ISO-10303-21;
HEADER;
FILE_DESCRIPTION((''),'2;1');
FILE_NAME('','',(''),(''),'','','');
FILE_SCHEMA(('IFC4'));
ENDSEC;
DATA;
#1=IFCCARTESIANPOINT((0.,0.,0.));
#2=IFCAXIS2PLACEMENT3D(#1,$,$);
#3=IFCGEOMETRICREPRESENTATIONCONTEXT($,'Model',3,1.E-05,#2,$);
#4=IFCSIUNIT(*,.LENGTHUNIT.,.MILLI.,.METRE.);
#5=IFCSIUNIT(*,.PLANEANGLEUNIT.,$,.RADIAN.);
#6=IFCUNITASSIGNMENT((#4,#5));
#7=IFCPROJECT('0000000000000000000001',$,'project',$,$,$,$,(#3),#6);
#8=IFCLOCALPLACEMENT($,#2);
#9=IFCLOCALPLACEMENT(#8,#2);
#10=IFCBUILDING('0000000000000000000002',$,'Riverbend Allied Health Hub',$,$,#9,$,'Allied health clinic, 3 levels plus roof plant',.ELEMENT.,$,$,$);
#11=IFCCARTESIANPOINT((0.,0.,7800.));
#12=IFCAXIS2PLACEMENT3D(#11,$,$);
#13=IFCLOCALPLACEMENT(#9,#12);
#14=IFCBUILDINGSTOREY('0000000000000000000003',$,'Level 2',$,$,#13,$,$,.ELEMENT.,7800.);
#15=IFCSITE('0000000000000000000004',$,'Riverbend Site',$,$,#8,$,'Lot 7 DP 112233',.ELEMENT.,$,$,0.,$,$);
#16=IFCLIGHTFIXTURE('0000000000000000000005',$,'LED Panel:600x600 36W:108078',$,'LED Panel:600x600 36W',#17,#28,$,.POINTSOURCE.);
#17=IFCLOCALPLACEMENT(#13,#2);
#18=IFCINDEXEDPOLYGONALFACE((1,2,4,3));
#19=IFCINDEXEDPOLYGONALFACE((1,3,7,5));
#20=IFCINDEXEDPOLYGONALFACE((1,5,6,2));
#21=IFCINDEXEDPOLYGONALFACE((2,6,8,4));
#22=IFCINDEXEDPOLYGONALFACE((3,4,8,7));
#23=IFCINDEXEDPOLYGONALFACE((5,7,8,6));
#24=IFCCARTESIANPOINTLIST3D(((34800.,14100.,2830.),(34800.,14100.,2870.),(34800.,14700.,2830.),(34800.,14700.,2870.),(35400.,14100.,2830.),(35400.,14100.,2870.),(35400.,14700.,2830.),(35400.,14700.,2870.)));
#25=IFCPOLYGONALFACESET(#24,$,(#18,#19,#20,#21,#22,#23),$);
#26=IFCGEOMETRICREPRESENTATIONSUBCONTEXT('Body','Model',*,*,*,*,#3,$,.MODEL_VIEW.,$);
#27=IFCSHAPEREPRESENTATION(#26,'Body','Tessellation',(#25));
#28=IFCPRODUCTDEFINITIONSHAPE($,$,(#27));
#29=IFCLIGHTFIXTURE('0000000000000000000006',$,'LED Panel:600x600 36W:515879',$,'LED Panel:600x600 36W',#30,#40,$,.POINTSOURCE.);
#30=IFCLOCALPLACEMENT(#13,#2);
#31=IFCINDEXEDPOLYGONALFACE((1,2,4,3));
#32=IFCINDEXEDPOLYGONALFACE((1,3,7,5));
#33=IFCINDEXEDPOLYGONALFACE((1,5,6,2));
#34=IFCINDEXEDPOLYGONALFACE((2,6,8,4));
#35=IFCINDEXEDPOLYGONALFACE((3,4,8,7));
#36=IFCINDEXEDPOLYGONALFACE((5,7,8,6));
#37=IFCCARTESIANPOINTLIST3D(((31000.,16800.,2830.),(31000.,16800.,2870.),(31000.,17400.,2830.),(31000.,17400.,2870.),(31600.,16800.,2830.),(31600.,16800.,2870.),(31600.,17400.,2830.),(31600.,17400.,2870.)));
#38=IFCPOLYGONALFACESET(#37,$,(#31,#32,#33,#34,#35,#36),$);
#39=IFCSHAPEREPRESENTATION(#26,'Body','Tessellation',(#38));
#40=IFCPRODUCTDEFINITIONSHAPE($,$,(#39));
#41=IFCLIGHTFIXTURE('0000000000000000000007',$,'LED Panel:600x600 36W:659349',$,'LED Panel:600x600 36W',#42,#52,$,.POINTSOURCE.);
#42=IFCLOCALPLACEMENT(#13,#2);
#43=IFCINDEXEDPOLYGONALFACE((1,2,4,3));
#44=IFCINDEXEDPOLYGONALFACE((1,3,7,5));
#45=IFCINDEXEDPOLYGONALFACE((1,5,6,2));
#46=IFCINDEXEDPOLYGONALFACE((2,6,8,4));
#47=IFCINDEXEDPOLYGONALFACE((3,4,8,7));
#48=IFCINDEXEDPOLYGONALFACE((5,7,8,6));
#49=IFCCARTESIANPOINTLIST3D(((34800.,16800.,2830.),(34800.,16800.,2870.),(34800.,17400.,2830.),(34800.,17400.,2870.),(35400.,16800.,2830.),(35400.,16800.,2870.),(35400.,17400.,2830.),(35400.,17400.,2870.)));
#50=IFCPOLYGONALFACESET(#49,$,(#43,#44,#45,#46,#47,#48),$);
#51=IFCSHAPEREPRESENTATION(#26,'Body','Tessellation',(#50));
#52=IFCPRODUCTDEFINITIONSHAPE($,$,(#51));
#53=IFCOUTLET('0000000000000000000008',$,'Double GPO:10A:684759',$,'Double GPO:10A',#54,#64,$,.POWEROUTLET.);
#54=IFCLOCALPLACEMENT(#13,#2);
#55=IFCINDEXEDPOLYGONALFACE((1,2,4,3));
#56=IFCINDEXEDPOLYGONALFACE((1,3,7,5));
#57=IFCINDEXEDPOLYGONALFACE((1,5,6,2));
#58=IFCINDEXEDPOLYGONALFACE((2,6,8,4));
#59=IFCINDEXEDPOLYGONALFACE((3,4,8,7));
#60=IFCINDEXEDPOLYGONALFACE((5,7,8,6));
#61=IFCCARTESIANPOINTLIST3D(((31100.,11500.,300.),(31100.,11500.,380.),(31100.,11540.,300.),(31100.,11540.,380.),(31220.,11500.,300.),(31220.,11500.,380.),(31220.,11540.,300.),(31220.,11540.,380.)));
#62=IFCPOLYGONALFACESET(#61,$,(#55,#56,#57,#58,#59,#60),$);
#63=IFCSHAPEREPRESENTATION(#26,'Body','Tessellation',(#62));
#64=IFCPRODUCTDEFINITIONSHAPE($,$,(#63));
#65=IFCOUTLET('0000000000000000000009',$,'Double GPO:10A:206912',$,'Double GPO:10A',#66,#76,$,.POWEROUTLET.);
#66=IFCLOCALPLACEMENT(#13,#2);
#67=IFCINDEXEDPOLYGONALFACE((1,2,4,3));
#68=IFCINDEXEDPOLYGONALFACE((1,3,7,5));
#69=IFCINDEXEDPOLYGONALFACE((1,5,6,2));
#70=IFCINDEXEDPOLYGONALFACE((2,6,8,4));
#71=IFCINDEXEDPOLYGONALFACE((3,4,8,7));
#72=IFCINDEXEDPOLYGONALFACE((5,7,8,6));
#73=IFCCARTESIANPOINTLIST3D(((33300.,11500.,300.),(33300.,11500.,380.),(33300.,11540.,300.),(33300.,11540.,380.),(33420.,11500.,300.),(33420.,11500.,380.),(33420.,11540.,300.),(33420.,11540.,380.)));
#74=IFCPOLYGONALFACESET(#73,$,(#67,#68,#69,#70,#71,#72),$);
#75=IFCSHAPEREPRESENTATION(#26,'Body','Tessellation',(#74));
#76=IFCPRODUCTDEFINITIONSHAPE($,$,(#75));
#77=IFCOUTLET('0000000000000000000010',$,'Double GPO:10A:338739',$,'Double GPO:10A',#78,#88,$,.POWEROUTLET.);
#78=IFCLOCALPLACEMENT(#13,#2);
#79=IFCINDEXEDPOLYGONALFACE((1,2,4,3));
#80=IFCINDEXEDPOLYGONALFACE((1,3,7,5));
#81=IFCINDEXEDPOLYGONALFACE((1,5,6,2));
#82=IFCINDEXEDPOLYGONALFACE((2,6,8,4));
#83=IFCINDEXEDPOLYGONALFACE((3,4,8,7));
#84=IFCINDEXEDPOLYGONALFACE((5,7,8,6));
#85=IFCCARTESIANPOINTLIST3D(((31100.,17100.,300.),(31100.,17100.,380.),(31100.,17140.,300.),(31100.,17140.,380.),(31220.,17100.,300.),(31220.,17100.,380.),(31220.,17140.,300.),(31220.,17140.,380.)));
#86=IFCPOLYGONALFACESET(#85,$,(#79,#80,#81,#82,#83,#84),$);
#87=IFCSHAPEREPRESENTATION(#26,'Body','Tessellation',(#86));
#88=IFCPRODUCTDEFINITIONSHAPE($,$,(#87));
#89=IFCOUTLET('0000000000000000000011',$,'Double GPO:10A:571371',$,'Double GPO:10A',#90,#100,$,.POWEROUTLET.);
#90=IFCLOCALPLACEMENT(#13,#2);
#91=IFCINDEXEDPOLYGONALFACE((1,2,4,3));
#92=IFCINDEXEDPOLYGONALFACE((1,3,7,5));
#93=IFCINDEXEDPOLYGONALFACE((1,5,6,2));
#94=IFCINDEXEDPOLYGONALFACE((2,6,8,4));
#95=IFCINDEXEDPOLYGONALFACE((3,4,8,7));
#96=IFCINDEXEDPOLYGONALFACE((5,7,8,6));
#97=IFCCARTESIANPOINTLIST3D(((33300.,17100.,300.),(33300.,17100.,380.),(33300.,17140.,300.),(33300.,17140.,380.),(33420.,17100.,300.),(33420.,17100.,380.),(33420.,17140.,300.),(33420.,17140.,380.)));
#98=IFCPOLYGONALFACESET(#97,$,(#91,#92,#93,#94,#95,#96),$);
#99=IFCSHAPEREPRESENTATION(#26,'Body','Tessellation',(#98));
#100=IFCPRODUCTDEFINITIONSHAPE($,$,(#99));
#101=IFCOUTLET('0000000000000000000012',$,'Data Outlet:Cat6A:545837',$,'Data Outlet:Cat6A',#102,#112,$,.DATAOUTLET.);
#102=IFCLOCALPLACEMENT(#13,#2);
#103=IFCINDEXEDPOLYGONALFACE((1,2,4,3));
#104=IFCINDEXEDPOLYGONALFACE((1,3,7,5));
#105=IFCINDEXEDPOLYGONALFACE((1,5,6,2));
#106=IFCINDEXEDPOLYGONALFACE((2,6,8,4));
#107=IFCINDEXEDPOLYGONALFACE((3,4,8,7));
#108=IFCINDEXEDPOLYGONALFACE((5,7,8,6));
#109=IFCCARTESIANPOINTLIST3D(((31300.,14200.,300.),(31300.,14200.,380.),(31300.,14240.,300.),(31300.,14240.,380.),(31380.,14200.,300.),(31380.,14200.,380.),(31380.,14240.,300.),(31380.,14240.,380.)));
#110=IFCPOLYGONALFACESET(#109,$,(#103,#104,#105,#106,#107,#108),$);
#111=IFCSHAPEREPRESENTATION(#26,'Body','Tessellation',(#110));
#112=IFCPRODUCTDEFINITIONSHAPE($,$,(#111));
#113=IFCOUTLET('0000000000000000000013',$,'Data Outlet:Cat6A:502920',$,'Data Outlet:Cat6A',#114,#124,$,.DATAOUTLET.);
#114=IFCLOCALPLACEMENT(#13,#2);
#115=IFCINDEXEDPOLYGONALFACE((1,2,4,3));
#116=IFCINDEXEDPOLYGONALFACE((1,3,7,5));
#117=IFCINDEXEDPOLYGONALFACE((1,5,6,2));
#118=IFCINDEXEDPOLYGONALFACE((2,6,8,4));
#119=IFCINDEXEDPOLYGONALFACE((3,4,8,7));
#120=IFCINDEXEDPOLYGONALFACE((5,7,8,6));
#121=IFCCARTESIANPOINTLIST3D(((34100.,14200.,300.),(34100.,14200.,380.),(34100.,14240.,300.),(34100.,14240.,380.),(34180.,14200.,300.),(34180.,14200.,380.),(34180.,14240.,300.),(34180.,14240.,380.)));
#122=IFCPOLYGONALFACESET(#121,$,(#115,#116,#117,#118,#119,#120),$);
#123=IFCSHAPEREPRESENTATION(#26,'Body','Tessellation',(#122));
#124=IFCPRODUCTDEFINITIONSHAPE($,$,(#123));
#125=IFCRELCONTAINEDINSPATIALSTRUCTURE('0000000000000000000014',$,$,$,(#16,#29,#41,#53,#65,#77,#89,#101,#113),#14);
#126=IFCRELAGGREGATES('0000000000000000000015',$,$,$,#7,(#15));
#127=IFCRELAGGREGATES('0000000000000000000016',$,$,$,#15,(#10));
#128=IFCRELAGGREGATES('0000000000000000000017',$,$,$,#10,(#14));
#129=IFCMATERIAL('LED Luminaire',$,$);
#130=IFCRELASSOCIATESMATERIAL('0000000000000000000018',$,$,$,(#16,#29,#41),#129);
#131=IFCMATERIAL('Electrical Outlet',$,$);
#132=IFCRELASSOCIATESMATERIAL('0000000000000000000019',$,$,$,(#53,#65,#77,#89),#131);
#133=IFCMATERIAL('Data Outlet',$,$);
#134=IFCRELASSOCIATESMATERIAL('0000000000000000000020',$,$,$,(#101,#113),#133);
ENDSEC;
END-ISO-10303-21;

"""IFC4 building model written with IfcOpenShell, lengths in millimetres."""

from ifc_helpers import new_model, si_unit, frame, frame_2d, origin, place, context, subcontext, project, spatial, rectangle, extrude, material, element, save


model = new_model("IFC4")

# Units and contexts
model_context = context("Model", 3, precision=1e-05, world=origin())
body_context = subcontext(model_context, "Body", "Model", "MODEL_VIEW")
ifc_project = project(units=[si_unit("LENGTHUNIT", "METRE", prefix="MILLI"), si_unit("PLANEANGLEUNIT", "RADIAN")], contexts=[model_context])

# Site, building, storey
site_placement = place(None, origin())
site = spatial("IfcSite", under=ifc_project, at=site_placement, Name="Riverbend Site", LongName="Lot 7 DP 112233", CompositionType="ELEMENT", RefElevation=0.0)
building_placement = place(site_placement, origin())
building = spatial("IfcBuilding", under=site, at=building_placement, Name="Riverbend Allied Health Hub", LongName="Allied health clinic, 3 levels plus roof plant", CompositionType="ELEMENT")
storey_placement = place(building_placement, frame((0.0, 0.0, 7800.0)))
storey = spatial("IfcBuildingStorey", under=building, at=storey_placement, Name="Level 2", CompositionType="ELEMENT", Elevation=7800.0)

# Light fixtures
ifc_material_1 = material(Name="LED Luminaire")
for number, where, name in (
    (1, (34800.0, 14100.0, 2830.0), "LED Panel:600x600 36W:108078"),
    (2, (31000.0, 16800.0, 2830.0), "LED Panel:600x600 36W:515879"),
    (3, (34800.0, 16800.0, 2830.0), "LED Panel:600x600 36W:659349"),
):
    element("IfcLightFixture", number, at=place(storey_placement, frame(where)), inside=storey, material=ifc_material_1, Name=name, ObjectType="LED Panel:600x600 36W", PredefinedType="POINTSOURCE", context=body_context, shape_type="SweptSolid", body=[
        extrude(rectangle(XDim=600.0, YDim=600.0, at=frame_2d((300.0, 300.0))), origin(), (0.0, 0.0, 1.0), 40.0),
    ])

# Outlets
ifc_material_2 = material(Name="Electrical Outlet")
for number, where, name in (
    (4, (31100.0, 11500.0, 300.0), "Double GPO:10A:684759"),
    (5, (33300.0, 11500.0, 300.0), "Double GPO:10A:206912"),
    (6, (31100.0, 17100.0, 300.0), "Double GPO:10A:338739"),
    (7, (33300.0, 17100.0, 300.0), "Double GPO:10A:571371"),
):
    element("IfcOutlet", number, at=place(storey_placement, frame(where)), inside=storey, material=ifc_material_2, Name=name, ObjectType="Double GPO:10A", PredefinedType="POWEROUTLET", context=body_context, shape_type="SweptSolid", body=[
        extrude(rectangle(XDim=120.0, YDim=40.0, at=frame_2d((60.0, 20.0))), origin(), (0.0, 0.0, 1.0), 80.0),
    ])
ifc_material_3 = material(Name="Data Outlet")
for number, where, name in (
    (8, (31300.0, 14200.0, 300.0), "Data Outlet:Cat6A:545837"),
    (9, (34100.0, 14200.0, 300.0), "Data Outlet:Cat6A:502920"),
):
    element("IfcOutlet", number, at=place(storey_placement, frame(where)), inside=storey, material=ifc_material_3, Name=name, ObjectType="Data Outlet:Cat6A", PredefinedType="DATAOUTLET", context=body_context, shape_type="SweptSolid", body=[
        extrude(rectangle(XDim=80.0, YDim=40.0, at=frame_2d((40.0, 20.0))), origin(), (0.0, 0.0, 1.0), 80.0),
    ])

save(model, "model.ifc")
